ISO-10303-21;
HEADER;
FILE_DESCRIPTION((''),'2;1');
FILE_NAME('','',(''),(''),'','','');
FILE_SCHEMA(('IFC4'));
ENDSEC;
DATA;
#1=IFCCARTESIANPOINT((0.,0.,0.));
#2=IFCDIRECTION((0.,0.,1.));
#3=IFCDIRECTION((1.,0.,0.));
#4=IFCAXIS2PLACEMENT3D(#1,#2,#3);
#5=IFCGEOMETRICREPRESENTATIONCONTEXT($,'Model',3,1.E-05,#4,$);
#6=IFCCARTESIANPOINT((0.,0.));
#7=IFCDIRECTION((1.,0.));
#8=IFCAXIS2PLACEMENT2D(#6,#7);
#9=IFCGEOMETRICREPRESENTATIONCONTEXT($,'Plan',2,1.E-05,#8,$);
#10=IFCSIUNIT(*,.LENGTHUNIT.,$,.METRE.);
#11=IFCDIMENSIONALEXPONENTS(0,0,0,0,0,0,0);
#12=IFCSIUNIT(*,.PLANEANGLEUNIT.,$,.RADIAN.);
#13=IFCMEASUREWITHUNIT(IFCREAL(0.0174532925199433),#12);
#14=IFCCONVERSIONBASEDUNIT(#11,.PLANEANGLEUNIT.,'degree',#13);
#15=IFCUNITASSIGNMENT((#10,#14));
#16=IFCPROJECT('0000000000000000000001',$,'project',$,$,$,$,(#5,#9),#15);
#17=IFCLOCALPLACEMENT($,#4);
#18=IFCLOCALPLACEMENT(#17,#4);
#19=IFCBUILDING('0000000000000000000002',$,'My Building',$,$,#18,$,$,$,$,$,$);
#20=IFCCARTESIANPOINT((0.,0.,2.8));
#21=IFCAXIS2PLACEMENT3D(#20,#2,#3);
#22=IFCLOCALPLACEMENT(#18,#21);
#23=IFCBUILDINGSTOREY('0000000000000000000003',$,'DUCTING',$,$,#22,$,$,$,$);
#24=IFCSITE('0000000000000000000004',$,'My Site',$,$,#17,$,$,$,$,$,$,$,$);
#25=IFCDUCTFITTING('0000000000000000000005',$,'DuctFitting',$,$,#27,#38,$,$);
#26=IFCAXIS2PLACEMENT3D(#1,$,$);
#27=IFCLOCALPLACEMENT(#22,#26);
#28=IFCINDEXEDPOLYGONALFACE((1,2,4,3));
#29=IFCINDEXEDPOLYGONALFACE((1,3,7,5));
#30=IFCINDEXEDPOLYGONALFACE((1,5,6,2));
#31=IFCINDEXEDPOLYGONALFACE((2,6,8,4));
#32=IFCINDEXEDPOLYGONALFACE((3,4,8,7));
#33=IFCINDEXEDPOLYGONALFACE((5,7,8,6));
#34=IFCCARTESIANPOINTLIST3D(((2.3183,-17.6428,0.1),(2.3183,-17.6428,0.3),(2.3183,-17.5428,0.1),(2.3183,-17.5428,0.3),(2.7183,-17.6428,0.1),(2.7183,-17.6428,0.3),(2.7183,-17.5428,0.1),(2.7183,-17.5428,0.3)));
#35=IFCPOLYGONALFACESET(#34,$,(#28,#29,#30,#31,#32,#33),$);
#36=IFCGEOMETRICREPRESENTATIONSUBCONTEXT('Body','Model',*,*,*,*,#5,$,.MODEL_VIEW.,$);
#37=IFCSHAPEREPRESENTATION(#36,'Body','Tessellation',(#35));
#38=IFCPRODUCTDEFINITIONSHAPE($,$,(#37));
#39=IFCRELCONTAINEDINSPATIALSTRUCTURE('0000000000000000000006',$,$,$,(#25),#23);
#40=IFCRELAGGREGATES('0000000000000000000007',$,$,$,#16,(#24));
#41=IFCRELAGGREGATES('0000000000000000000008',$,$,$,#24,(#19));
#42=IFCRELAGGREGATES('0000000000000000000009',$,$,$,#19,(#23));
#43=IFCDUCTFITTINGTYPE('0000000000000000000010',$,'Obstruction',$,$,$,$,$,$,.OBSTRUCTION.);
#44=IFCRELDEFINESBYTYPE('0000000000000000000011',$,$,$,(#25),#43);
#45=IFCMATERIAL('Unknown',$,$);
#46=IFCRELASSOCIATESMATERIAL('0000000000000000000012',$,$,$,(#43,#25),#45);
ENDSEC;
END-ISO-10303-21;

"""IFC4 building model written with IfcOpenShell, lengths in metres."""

from ifc_helpers import new_model, entity, si_unit, converted_unit, frame, origin_with_axes, origin_2d_with_axis, place, context, subcontext, project, spatial, rectangle, extrude, material, material_profile, profile_set, profile_usage, type_object, element, save


model = new_model("IFC4")

# Units and contexts
model_context = context("Model", 3, precision=1e-05, world=origin_with_axes())
plan_context = context("Plan", 2, precision=1e-05, world=origin_2d_with_axis())
body_context = subcontext(model_context, "Body", "Model", "MODEL_VIEW")
ifc_project = project(units=[si_unit("LENGTHUNIT", "METRE"), converted_unit("PLANEANGLEUNIT", "degree", entity("IfcReal", 0.0174532925199433), si_unit("PLANEANGLEUNIT", "RADIAN"), dimensions=[0, 0, 0, 0, 0, 0, 0])], contexts=[model_context, plan_context])

# Site, building, storey
site_placement = place(None, origin_with_axes())
site = spatial("IfcSite", under=ifc_project, at=site_placement, Name="My Site")
building_placement = place(site_placement, origin_with_axes())
building = spatial("IfcBuilding", under=site, at=building_placement, Name="My Building")
storey_placement = place(building_placement, frame((0.0, 0.0, 2.8), z_axis=(0.0, 0.0, 1.0), x_axis=(1.0, 0.0, 0.0)))
storey = spatial("IfcBuildingStorey", under=building, at=storey_placement, Name="DUCTING")

# Shared definitions
ifc_material = material(Name="Unknown")

# Duct fitting
ifc_material_profile_1 = material_profile(ifc_material, rectangle(XDim=0.4, YDim=0.2))
ifc_profile_set_1 = profile_set([ifc_material_profile_1])
duct_fitting_type_1 = type_object("IfcDuctFittingType", Name="Obstruction", PredefinedType="OBSTRUCTION", material=ifc_profile_set_1)
ifc_profile_usage_1 = profile_usage(ifc_profile_set_1, cardinal=5)
duct_fitting_1_placement = place(storey_placement, frame((2.5183, -17.6428, 0.2), z_axis=(0.0, 1.0, 0.0), x_axis=(-1.0, 0.0, 0.0)))
element("IfcDuctFitting", 1, at=duct_fitting_1_placement, inside=storey, type_object=duct_fitting_type_1, material=ifc_profile_usage_1, Name="DuctFitting", context=body_context, shape_type="SweptSolid", body=[
    extrude(rectangle(XDim=0.4, YDim=0.2), origin_with_axes(), (0.0, 0.0, 1.0), 0.1),
])

save(model, "model.ifc")
